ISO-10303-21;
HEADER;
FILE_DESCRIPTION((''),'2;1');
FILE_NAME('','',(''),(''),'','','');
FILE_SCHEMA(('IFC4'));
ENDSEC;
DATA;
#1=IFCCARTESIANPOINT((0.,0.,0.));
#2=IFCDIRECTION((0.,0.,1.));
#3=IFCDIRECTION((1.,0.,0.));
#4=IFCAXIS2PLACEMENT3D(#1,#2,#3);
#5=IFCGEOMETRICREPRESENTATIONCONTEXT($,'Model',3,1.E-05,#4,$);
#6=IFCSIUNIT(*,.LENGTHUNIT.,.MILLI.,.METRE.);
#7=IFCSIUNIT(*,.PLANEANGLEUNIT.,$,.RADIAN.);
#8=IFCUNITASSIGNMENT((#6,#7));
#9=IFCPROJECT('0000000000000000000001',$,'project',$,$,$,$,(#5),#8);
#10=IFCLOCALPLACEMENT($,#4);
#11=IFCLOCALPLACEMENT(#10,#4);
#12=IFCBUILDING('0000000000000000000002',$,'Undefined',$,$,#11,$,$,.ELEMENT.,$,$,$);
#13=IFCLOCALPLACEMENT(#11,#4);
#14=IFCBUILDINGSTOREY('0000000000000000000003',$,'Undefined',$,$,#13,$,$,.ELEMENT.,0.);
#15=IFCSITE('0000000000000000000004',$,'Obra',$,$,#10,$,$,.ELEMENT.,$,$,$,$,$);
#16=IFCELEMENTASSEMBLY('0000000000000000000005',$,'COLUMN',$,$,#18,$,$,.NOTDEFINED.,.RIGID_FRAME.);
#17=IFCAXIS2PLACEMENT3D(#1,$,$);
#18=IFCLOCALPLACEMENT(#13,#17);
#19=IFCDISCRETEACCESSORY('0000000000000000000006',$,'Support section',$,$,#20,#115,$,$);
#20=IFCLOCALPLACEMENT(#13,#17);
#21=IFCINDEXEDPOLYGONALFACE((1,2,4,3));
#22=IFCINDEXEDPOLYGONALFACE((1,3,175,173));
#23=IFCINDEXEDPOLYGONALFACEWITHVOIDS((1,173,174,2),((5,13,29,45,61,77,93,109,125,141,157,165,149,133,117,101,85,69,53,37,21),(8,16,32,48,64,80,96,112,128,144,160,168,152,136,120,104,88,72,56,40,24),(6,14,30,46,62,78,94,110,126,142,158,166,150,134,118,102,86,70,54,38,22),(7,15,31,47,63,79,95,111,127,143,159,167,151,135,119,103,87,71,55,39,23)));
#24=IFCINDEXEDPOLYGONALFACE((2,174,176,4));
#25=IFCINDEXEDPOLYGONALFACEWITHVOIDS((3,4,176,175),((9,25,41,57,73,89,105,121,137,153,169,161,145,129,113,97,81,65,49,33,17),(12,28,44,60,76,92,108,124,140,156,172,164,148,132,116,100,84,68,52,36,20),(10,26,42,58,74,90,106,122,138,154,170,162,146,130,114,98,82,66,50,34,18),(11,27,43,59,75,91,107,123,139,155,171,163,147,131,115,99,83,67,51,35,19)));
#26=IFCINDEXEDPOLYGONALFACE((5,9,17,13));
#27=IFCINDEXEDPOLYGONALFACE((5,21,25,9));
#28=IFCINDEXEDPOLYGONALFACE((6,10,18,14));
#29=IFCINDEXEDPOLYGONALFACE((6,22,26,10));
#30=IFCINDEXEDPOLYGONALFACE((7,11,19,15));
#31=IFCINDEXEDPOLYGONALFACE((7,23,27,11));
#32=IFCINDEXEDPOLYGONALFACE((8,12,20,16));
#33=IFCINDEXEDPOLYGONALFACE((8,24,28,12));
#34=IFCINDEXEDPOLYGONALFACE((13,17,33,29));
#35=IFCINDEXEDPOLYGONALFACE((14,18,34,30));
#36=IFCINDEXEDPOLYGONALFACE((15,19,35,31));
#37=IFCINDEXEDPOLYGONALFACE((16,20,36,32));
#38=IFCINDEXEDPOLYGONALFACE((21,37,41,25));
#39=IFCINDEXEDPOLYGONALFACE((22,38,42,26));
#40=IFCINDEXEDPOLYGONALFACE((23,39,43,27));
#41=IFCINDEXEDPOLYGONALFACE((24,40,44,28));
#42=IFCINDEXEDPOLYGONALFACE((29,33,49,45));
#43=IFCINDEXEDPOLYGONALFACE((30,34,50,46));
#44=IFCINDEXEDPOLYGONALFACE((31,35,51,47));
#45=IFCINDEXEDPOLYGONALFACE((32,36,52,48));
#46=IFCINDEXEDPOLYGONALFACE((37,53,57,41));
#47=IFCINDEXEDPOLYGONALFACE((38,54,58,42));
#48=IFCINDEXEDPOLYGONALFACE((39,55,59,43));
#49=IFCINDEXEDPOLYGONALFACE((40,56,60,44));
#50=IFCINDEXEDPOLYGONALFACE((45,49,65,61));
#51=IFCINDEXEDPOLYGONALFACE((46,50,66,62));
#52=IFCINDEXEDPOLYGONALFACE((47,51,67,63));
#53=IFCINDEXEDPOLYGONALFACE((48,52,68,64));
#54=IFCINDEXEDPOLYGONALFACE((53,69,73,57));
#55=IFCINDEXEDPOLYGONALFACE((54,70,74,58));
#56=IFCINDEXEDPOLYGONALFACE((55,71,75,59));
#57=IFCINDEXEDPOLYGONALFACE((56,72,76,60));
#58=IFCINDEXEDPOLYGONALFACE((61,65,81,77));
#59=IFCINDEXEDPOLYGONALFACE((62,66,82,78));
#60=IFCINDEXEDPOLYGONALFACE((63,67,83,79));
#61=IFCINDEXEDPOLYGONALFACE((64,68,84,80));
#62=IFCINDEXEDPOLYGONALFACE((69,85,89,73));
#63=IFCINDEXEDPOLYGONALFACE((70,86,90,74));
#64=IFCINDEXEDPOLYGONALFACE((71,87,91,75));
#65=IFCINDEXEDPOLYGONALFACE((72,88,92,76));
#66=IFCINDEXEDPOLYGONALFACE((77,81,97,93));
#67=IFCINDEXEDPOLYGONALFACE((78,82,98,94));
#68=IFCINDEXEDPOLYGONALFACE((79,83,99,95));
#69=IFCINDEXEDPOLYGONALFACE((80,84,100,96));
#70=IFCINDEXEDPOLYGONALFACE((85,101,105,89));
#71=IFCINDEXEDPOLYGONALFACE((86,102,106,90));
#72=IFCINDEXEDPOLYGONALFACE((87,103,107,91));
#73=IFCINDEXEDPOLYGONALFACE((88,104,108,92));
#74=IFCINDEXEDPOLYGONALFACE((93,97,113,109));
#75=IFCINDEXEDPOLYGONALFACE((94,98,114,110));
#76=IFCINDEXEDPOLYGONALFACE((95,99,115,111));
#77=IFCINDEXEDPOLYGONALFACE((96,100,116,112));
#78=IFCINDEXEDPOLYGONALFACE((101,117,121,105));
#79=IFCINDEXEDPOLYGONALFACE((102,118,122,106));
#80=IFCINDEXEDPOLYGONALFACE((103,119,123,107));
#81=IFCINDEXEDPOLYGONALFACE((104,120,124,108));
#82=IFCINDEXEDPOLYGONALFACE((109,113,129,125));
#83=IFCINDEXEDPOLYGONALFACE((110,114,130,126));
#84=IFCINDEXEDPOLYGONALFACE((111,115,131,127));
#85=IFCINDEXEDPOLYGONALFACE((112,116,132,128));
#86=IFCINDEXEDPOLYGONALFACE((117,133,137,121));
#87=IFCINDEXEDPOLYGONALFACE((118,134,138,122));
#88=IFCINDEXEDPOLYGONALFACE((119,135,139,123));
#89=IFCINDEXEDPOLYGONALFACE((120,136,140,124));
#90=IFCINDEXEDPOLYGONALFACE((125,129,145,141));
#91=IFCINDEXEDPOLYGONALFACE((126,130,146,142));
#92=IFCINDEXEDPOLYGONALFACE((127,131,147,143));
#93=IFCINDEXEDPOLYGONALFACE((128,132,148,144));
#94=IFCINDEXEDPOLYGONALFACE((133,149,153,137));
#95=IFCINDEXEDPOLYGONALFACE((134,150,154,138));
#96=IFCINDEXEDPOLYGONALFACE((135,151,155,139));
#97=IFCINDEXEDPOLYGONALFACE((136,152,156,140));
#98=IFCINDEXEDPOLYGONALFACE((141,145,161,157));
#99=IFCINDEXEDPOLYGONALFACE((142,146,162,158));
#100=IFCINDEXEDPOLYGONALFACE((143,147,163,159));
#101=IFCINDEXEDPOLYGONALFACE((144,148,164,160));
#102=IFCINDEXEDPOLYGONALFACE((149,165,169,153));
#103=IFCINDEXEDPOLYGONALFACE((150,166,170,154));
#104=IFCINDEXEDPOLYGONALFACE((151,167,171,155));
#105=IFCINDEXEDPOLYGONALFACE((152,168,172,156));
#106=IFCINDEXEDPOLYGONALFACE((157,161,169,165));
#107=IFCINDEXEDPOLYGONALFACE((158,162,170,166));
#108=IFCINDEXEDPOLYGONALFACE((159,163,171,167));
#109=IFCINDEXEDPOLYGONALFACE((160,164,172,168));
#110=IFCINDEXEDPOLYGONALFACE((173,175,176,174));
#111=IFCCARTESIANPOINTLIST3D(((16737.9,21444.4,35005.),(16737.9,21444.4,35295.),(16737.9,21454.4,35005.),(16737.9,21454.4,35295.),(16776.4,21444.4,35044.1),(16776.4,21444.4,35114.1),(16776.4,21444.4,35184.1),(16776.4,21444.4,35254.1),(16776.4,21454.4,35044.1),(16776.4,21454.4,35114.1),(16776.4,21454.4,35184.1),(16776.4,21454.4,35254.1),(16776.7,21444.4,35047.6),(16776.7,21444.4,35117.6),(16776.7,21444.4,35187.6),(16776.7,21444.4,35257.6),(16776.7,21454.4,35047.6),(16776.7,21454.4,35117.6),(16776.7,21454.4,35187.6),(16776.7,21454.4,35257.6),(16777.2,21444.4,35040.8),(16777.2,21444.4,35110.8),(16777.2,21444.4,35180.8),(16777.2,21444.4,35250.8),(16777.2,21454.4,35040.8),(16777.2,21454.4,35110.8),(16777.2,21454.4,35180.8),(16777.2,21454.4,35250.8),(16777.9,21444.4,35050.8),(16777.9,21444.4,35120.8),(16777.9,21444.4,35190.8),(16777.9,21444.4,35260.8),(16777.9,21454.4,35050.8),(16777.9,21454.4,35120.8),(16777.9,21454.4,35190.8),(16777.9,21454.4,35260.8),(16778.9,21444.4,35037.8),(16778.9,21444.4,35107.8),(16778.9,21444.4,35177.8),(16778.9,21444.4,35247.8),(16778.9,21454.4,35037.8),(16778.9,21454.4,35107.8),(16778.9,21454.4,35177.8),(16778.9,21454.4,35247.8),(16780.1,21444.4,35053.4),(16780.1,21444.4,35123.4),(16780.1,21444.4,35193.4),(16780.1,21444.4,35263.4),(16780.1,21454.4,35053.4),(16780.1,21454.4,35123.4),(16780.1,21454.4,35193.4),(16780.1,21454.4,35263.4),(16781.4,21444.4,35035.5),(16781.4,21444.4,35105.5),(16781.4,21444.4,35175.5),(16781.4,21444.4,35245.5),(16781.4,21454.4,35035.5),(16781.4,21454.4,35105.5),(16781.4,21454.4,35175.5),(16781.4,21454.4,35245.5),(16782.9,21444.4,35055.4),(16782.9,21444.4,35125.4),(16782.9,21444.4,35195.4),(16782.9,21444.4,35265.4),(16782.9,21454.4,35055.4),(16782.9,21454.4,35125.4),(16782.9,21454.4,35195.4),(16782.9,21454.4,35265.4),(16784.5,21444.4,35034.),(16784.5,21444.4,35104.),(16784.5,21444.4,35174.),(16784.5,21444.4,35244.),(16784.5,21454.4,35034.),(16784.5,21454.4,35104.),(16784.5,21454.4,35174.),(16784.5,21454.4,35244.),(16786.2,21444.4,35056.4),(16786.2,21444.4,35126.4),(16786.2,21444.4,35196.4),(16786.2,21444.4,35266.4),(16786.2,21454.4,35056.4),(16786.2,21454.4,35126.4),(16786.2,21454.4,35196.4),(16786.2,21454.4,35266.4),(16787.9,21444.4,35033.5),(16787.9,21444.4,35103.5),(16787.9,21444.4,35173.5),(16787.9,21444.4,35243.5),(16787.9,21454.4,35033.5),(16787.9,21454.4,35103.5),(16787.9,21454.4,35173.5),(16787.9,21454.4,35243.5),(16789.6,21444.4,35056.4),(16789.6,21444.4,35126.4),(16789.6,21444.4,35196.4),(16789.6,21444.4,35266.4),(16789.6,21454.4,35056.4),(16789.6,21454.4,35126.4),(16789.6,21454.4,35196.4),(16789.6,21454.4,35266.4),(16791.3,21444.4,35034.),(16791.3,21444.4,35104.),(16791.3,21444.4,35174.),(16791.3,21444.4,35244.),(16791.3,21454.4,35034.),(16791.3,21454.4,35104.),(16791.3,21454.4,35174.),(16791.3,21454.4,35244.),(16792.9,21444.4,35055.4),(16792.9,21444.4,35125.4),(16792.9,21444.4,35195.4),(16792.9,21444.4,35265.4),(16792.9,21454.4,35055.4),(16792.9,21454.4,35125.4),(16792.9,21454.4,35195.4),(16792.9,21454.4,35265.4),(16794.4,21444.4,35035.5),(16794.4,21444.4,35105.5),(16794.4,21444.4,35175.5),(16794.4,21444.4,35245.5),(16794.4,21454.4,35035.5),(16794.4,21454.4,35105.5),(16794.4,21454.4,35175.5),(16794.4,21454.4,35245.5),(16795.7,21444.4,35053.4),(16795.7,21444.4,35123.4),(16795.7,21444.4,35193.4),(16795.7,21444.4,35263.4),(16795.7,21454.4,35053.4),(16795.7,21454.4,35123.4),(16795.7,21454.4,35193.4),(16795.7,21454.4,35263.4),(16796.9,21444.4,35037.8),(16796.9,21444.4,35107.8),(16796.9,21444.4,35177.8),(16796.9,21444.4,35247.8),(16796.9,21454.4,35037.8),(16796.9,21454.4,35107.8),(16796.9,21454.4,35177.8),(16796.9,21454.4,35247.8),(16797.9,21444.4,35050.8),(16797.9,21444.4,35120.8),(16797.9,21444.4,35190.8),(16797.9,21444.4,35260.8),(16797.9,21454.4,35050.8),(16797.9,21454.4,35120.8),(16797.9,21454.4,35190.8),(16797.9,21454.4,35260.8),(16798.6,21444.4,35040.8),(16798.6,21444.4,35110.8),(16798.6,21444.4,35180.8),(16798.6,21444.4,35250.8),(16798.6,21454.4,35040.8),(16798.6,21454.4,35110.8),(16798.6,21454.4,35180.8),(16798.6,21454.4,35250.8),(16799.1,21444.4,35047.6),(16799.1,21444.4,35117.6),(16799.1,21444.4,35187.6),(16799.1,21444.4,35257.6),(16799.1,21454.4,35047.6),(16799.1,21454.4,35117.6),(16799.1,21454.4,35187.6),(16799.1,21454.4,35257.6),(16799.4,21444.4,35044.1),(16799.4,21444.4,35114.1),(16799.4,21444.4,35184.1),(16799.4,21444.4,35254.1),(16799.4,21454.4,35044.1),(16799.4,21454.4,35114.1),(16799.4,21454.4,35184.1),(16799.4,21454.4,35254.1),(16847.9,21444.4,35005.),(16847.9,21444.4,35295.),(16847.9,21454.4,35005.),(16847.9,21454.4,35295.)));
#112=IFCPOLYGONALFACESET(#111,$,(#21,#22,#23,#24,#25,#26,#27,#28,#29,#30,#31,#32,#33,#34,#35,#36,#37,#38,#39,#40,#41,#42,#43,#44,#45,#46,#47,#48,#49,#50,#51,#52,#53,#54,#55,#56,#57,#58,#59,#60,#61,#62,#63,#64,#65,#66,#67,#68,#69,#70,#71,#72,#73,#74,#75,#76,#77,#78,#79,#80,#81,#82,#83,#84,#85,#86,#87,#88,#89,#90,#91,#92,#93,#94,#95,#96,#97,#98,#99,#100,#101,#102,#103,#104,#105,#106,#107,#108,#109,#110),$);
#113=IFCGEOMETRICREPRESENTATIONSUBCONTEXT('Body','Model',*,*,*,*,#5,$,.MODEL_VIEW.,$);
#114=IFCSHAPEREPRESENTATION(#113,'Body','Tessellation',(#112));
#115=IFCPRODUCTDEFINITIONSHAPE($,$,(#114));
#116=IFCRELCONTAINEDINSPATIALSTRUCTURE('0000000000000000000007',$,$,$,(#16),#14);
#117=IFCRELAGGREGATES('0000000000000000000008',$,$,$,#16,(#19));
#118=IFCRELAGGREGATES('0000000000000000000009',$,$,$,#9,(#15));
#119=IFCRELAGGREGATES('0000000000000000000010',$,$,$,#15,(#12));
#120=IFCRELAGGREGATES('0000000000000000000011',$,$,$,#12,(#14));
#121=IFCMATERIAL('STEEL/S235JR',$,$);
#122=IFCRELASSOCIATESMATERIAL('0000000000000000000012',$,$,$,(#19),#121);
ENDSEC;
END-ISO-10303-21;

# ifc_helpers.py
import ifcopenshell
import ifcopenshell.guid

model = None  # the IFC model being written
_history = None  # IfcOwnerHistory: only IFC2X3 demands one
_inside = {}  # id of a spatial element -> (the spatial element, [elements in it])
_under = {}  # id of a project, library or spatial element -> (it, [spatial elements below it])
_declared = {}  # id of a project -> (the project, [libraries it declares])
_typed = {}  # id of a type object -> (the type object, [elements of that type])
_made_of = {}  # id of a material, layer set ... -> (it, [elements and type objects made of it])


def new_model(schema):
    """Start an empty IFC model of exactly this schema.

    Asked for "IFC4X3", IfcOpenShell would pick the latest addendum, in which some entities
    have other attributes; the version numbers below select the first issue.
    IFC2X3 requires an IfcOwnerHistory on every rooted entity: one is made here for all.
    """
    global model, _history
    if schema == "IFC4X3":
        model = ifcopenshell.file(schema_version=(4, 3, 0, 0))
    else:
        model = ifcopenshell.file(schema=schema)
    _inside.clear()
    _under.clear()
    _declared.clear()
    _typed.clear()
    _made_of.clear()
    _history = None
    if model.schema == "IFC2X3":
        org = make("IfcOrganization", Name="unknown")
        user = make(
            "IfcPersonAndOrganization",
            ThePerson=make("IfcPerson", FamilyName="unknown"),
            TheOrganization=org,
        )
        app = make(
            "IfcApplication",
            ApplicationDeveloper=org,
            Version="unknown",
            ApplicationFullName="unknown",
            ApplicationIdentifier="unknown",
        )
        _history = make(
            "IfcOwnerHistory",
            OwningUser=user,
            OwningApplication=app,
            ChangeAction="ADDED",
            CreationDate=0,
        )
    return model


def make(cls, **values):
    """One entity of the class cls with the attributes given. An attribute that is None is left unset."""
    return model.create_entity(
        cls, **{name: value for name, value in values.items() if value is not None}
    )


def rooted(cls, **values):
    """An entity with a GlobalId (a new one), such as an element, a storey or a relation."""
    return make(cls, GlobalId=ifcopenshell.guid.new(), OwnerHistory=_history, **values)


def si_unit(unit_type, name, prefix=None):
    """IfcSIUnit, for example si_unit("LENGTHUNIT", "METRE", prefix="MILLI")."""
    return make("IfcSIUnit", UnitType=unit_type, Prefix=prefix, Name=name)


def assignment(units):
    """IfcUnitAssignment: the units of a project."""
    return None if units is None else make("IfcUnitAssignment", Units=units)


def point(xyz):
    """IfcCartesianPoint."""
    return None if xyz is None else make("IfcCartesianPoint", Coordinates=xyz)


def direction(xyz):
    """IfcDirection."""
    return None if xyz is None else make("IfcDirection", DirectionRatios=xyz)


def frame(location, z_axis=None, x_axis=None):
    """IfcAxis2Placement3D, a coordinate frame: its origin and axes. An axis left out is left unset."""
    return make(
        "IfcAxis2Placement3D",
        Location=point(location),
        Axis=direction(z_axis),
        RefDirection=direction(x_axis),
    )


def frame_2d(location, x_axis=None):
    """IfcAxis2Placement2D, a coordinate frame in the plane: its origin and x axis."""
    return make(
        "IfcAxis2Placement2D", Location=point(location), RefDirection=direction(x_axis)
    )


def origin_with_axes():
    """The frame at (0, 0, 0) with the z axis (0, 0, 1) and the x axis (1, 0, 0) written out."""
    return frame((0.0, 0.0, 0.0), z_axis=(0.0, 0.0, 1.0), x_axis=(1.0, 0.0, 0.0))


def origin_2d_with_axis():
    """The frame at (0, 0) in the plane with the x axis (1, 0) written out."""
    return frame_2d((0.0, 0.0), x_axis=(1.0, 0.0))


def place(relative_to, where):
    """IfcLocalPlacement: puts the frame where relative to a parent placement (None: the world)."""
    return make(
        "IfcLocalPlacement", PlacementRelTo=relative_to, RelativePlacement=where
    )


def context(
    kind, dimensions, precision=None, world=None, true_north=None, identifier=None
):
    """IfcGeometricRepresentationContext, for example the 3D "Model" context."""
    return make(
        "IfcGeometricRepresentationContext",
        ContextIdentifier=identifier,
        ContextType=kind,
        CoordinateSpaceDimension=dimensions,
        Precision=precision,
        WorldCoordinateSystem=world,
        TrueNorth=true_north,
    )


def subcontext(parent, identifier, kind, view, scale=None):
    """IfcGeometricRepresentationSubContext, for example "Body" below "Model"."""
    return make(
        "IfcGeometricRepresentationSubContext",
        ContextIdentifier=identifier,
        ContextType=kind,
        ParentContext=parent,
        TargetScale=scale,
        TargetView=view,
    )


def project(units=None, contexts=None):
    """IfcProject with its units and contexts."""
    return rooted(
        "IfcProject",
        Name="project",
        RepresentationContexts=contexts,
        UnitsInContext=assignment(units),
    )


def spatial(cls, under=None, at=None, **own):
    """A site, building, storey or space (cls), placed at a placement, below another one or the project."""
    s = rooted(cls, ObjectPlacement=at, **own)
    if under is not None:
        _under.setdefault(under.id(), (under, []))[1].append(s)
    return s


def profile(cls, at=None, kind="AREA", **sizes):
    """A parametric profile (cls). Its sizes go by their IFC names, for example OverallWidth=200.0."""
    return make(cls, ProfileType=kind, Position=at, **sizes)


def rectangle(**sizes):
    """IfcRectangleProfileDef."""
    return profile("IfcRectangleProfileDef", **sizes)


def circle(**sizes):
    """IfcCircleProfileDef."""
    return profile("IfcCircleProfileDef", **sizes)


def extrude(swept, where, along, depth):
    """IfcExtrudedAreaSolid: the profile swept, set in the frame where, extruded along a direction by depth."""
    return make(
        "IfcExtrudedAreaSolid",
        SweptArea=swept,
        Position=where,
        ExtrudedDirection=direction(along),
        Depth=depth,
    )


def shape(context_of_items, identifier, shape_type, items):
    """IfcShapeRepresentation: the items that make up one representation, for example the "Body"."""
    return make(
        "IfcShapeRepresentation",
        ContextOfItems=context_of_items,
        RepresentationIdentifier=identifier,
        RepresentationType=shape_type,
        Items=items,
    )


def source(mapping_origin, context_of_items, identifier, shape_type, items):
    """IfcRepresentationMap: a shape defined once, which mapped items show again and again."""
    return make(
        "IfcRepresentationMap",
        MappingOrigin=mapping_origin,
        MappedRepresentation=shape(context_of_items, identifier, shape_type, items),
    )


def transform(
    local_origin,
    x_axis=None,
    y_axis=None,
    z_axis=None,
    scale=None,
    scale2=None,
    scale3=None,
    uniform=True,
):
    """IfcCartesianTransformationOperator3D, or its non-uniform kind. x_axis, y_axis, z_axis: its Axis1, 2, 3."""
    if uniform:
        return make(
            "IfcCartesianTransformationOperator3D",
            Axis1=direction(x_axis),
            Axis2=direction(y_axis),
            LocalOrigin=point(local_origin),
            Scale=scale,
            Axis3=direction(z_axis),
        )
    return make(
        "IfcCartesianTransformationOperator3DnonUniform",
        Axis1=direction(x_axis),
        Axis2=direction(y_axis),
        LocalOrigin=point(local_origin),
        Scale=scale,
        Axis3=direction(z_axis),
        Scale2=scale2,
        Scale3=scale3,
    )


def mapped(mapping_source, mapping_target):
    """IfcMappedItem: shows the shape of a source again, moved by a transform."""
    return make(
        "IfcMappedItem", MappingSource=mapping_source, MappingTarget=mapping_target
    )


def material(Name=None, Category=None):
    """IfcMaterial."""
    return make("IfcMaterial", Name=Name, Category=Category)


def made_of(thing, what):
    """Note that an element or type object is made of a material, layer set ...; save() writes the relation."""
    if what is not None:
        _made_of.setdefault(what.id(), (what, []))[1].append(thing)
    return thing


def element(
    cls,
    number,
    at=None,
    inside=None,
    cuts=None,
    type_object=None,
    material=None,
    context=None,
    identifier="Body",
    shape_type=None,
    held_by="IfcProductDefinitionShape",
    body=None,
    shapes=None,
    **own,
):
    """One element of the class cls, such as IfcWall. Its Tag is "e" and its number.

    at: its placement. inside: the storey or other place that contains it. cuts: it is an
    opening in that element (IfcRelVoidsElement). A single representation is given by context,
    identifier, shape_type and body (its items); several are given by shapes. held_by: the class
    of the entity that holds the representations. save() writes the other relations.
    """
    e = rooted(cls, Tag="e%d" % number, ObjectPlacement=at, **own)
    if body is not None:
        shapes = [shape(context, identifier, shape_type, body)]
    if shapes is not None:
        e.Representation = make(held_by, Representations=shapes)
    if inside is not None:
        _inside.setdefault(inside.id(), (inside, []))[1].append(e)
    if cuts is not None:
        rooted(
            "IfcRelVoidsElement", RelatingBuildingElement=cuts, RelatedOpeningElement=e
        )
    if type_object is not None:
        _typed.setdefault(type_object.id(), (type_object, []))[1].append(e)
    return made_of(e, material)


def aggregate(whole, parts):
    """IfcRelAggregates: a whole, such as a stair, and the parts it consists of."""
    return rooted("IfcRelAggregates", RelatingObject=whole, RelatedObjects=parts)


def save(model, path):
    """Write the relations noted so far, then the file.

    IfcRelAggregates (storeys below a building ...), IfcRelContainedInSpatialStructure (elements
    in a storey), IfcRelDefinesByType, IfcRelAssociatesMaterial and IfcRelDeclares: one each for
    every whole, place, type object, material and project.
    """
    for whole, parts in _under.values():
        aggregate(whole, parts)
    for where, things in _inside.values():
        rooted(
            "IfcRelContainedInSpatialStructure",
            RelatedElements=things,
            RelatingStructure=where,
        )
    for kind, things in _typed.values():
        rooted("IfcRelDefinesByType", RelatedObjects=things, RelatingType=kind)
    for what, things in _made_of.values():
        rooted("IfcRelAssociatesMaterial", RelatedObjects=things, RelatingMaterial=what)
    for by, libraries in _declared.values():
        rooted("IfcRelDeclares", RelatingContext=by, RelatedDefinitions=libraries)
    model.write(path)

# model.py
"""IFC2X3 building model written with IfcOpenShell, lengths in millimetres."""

from ifc_helpers import new_model, si_unit, frame, origin_with_axes, origin_2d_with_axis, place, context, subcontext, project, spatial, rectangle, circle, extrude, source, transform, mapped, material, element, aggregate, save


model = new_model("IFC2X3")

# Units and contexts
model_context = context("Model", 3, precision=1e-05, world=origin_with_axes())
body_context = subcontext(model_context, "Body", "Model", "MODEL_VIEW")
ifc_project = project(units=[si_unit("LENGTHUNIT", "METRE", prefix="MILLI"), si_unit("PLANEANGLEUNIT", "RADIAN")], contexts=[model_context])

# Site, building, storey
site_placement = place(None, origin_with_axes())
site = spatial("IfcSite", under=ifc_project, at=site_placement, Name="Obra", CompositionType="ELEMENT")
building_placement = place(site_placement, origin_with_axes())
building = spatial("IfcBuilding", under=site, at=building_placement, Name="Undefined", CompositionType="ELEMENT")
storey_placement = place(building_placement, origin_with_axes())
storey = spatial("IfcBuildingStorey", under=building, at=storey_placement, Name="Undefined", CompositionType="ELEMENT", Elevation=0.0)

# Element assembly
assembly_1_placement = place(storey_placement, origin_with_axes())
assembly_1 = element("IfcElementAssembly", 1, at=assembly_1_placement, inside=storey, Name="COLUMN", AssemblyPlace="NOTDEFINED", PredefinedType="RIGID_FRAME")
ifc_material_1 = material(Name="STEEL/S235JR")
shared_shape_1 = source(origin_with_axes(), body_context, "Body", "SweptSolid", [
    extrude(circle(Radius=11.5, at=origin_2d_with_axis()), frame((0.0, -14.4, 0.0), z_axis=(0.0, 1.0, 0.0), x_axis=(1.0, 0.0, 0.0)), (0.0, 0.0, 1.0), 10.2),
])

# Discrete accessory, opening
discrete_accessory_1_placement = place(assembly_1_placement, frame((16792.9, 21449.4, 35005.0), z_axis=(0.0, 0.0, 1.0), x_axis=(1.0, 0.0, 0.0)))
discrete_accessory_1 = element("IfcDiscreteAccessory", 2, at=discrete_accessory_1_placement, material=ifc_material_1, Name="Support section", context=body_context, shape_type="SweptSolid", body=[
    extrude(rectangle(XDim=10.0, YDim=110.0, at=origin_2d_with_axis()), frame((0.0, 0.0, 290.0), z_axis=(0.0, 0.0, -1.0), x_axis=(0.0, 1.0, 0.0)), (0.0, 0.0, 1.0), 290.0),
])
opening_1_placement = place(assembly_1_placement, frame((16837.9, 21440.1, 35350.0), z_axis=(-1.0, 0.0, 0.0), x_axis=(0.0, 0.0, -1.0)))
element("IfcOpeningElement", 3, at=opening_1_placement, cuts=discrete_accessory_1, ObjectType="Opening", context=body_context, shape_type="MappedRepresentation", body=[
    mapped(shared_shape_1, transform((95.0, 0.0, 50.0))),
    mapped(shared_shape_1, transform((165.0, 0.0, 50.0))),
    mapped(shared_shape_1, transform((235.0, 0.0, 50.0))),
    mapped(shared_shape_1, transform((305.0, 0.0, 50.0))),
])
aggregate(assembly_1, [discrete_accessory_1])

save(model, "model.ifc")
